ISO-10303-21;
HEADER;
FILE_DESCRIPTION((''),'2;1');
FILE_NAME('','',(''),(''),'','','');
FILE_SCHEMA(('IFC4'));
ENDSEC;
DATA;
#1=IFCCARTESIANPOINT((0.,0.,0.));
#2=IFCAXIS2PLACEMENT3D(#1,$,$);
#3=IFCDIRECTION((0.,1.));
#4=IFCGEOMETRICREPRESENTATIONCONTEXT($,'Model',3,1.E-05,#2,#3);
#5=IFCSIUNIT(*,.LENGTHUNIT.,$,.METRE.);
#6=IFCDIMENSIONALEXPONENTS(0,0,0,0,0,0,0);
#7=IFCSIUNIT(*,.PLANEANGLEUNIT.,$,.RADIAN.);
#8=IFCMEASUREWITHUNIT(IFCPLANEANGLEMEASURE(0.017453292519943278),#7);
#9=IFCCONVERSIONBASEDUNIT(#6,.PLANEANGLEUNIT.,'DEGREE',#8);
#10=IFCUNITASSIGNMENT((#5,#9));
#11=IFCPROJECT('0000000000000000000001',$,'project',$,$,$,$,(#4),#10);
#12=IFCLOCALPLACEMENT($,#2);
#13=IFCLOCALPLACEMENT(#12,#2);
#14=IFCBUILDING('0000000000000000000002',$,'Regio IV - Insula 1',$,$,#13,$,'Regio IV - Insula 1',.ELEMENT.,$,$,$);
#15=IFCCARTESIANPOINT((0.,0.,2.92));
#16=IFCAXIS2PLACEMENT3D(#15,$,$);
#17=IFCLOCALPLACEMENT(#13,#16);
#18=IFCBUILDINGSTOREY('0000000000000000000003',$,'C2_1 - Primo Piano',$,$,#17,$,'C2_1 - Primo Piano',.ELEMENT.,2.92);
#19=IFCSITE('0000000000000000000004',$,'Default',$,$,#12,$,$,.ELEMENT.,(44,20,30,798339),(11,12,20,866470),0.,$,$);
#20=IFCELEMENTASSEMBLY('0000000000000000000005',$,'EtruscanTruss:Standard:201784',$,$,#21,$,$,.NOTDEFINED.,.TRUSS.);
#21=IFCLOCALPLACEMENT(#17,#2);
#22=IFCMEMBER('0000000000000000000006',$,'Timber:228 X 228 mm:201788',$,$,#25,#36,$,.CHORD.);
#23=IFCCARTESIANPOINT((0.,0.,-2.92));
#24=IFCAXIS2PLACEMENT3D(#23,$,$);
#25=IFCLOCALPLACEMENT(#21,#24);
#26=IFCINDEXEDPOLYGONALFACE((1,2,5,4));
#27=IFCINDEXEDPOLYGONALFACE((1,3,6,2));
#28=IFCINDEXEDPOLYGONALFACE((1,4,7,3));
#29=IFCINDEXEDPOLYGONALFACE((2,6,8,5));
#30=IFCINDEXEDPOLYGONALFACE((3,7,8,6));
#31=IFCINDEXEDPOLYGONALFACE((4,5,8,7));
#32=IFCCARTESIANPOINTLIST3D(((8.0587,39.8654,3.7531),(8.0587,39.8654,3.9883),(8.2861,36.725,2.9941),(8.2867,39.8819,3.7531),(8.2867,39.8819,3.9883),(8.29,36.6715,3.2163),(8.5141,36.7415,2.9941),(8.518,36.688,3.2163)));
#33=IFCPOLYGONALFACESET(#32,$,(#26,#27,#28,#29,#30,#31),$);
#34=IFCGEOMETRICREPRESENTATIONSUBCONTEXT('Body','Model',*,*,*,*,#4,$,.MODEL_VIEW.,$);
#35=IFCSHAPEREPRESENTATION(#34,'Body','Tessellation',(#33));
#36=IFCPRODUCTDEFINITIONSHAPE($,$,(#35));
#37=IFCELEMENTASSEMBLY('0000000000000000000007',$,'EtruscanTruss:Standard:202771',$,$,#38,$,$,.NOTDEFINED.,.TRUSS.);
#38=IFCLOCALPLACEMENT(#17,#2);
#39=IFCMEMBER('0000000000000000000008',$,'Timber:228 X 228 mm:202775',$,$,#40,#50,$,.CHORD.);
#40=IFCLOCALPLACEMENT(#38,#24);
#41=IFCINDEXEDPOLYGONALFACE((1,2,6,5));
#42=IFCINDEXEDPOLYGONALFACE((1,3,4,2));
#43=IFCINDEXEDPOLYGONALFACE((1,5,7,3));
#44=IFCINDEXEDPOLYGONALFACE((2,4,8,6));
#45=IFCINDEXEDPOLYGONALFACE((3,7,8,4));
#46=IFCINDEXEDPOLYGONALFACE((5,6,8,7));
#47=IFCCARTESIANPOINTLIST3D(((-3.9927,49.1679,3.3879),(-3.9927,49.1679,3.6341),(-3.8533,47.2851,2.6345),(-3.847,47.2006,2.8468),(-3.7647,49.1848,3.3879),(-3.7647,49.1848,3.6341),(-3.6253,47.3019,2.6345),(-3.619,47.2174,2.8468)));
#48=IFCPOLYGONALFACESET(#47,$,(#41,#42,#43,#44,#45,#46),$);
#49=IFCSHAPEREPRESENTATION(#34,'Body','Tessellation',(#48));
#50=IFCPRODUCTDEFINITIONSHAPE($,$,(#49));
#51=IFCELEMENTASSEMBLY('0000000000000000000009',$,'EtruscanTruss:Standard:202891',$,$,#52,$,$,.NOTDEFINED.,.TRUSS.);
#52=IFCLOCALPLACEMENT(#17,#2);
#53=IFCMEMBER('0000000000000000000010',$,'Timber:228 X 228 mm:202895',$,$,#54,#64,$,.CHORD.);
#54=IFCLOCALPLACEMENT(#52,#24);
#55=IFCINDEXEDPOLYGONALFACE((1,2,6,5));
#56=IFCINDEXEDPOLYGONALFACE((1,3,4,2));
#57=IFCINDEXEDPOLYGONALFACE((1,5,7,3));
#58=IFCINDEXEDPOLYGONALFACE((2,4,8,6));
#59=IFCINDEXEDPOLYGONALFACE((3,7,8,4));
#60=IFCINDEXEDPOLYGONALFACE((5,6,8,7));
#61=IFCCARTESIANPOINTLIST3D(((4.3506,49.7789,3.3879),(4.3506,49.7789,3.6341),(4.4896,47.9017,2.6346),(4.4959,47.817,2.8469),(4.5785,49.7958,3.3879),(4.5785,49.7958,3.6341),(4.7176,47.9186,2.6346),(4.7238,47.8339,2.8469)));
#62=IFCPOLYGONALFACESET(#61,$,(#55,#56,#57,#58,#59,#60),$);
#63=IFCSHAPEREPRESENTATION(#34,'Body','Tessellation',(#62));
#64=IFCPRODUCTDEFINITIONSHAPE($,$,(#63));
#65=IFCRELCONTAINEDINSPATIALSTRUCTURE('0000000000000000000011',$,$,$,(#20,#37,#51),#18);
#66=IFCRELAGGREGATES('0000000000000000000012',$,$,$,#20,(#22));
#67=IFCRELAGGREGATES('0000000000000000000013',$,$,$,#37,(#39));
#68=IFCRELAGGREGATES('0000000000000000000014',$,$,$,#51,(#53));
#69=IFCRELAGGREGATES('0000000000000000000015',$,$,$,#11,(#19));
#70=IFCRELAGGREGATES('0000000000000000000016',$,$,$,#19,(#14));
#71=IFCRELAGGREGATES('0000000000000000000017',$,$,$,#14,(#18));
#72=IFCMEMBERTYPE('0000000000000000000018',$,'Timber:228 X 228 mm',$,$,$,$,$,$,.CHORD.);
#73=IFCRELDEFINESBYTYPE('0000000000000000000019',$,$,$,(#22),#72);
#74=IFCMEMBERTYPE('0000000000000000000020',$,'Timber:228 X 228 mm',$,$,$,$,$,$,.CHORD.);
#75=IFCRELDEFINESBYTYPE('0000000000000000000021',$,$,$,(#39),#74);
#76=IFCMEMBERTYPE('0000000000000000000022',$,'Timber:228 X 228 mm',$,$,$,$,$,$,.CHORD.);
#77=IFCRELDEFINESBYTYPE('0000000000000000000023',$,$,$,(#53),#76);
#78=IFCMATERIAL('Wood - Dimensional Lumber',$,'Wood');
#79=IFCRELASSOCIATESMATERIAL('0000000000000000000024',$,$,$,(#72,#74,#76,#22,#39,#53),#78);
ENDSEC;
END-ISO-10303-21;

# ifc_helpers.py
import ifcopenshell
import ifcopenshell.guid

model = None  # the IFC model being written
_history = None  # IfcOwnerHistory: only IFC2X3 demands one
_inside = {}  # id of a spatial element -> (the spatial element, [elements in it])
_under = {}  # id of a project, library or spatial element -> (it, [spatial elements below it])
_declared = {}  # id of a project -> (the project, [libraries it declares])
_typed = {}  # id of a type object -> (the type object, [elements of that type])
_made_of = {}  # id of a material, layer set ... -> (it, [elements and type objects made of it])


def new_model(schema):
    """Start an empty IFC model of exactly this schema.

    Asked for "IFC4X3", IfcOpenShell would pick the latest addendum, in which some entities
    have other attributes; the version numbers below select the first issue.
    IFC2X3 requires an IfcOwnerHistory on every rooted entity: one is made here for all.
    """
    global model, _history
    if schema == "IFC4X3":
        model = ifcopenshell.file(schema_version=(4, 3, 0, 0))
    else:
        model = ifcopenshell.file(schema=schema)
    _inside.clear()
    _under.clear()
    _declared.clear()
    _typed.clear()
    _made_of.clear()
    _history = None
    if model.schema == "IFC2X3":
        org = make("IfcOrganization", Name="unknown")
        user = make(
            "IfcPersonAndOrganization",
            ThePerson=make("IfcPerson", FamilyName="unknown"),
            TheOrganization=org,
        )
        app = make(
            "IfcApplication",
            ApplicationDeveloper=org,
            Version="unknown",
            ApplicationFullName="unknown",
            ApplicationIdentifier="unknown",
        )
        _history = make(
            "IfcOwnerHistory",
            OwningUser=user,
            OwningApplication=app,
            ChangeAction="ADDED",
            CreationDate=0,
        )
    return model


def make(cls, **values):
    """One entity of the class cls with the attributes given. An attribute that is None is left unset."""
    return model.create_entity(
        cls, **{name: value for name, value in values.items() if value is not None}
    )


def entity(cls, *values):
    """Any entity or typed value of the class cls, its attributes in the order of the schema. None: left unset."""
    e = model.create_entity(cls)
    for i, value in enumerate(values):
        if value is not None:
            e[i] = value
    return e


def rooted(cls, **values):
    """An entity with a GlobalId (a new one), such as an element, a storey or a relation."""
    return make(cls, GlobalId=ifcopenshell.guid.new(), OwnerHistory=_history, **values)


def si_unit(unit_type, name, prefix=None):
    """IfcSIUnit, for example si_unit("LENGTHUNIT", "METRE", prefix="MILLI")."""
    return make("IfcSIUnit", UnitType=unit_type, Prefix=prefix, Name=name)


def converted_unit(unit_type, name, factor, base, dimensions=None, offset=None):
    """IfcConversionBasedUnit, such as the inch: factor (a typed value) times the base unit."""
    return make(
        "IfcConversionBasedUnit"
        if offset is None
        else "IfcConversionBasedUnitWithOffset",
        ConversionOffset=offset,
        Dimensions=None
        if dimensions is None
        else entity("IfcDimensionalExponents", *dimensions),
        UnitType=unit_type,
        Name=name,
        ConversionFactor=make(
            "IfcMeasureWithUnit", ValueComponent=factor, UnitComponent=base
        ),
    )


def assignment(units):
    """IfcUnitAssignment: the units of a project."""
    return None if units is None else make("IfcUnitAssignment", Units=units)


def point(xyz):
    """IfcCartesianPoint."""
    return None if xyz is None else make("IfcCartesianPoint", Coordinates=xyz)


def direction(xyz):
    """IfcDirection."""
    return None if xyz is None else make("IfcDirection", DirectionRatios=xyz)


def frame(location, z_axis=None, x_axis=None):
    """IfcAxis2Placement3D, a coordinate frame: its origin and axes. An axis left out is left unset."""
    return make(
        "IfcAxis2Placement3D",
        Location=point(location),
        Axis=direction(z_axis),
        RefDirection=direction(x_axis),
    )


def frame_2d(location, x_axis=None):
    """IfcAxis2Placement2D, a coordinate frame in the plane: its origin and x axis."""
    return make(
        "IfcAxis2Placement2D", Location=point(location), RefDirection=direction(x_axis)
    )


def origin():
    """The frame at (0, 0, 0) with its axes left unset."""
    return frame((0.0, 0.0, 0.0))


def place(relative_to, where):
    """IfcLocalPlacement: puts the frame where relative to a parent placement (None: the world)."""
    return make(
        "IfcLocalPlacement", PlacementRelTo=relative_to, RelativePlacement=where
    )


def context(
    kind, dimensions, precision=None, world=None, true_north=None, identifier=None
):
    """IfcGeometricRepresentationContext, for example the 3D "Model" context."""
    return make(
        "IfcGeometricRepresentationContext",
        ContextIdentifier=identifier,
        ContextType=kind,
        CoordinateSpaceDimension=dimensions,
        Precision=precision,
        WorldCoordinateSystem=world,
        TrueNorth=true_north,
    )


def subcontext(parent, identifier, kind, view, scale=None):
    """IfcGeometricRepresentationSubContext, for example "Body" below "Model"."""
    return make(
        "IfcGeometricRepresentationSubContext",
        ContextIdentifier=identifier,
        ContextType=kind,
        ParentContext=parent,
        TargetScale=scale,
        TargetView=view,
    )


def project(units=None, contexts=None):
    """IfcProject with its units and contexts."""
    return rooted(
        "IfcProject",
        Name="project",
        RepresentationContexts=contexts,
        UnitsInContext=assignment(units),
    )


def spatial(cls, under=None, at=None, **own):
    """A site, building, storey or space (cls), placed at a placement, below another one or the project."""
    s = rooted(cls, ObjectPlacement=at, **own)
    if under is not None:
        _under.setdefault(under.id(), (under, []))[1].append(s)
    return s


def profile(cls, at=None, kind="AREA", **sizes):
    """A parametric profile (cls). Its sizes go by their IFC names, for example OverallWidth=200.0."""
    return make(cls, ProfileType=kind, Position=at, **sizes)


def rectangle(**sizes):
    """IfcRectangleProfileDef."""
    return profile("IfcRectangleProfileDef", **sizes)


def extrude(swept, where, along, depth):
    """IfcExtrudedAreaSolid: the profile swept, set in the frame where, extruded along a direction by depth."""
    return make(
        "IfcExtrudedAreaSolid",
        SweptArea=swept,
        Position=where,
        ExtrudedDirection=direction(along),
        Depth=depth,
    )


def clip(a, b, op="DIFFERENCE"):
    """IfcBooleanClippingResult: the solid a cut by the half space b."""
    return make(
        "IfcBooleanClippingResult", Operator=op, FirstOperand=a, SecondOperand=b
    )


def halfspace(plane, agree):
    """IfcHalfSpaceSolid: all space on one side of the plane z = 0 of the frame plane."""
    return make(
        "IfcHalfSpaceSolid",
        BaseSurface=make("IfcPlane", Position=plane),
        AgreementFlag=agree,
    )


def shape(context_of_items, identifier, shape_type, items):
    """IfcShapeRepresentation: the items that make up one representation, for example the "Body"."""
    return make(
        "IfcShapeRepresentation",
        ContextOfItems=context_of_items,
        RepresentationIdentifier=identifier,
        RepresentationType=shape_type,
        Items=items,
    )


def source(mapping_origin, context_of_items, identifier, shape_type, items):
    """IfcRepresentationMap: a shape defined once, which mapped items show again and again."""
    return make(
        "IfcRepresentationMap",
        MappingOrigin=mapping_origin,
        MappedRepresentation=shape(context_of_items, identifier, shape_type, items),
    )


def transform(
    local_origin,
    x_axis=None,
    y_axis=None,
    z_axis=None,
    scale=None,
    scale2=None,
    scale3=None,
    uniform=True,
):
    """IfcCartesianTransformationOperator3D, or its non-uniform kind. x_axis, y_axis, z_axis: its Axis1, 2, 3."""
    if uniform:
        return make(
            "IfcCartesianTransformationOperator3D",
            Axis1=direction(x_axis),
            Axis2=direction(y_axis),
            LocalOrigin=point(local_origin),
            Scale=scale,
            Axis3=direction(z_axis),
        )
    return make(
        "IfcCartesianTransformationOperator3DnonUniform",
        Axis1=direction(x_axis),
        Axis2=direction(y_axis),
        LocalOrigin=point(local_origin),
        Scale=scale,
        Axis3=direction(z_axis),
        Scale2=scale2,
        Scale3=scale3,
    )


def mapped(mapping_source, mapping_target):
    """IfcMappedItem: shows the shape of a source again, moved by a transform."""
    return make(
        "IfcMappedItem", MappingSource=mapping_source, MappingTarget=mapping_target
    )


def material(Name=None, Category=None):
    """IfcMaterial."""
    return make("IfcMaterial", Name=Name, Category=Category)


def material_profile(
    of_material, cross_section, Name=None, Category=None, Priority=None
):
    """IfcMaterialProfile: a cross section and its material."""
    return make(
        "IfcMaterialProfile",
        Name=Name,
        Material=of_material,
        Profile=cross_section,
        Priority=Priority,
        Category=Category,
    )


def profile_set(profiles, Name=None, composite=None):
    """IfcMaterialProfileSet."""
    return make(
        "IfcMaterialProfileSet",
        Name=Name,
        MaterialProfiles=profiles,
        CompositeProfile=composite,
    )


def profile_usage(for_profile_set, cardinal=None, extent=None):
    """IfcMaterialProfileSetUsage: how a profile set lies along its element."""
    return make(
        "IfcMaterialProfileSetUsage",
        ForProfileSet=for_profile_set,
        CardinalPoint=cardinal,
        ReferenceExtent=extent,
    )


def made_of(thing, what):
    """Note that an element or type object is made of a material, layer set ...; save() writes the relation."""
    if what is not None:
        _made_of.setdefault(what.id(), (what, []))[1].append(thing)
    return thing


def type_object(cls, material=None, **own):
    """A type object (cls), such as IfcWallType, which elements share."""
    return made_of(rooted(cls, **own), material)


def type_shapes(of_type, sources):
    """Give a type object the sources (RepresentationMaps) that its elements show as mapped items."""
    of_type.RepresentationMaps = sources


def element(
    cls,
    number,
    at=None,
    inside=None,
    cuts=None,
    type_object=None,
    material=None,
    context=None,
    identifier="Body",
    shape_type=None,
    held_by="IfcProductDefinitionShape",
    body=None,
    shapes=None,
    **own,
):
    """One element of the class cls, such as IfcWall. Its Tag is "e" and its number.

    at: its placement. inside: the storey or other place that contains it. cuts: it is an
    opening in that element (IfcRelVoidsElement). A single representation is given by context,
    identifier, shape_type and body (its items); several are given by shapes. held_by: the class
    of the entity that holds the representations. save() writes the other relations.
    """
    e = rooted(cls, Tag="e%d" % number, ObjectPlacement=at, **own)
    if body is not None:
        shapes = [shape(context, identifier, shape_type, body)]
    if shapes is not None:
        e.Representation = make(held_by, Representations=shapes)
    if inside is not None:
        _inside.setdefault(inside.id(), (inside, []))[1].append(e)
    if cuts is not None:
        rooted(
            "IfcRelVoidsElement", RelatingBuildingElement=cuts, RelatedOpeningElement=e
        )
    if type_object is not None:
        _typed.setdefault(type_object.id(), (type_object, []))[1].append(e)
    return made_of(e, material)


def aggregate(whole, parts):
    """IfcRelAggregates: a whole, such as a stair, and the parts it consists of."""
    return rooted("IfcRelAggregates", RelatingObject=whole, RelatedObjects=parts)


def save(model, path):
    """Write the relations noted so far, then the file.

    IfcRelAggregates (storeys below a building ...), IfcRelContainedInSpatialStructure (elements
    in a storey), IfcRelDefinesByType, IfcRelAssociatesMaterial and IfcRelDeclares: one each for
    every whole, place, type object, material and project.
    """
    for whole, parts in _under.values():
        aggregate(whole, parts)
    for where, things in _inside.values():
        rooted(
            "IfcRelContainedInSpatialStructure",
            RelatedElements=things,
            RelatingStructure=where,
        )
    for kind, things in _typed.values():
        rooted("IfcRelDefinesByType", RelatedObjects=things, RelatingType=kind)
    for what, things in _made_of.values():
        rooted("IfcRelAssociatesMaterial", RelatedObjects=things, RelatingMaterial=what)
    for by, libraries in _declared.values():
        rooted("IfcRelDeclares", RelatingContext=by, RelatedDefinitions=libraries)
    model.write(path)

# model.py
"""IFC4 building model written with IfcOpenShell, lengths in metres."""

from ifc_helpers import new_model, entity, si_unit, converted_unit, direction, frame, frame_2d, origin, place, context, subcontext, project, spatial, rectangle, extrude, clip, halfspace, source, transform, mapped, material, material_profile, profile_set, profile_usage, type_object, type_shapes, element, aggregate, save


model = new_model("IFC4")

# Units and contexts
model_context = context("Model", 3, precision=1e-05, world=origin(), true_north=direction((0.0, 1.0)))
body_context = subcontext(model_context, "Body", "Model", "MODEL_VIEW")
ifc_project = project(units=[si_unit("LENGTHUNIT", "METRE"), converted_unit("PLANEANGLEUNIT", "DEGREE", entity("IfcPlaneAngleMeasure", 0.017453292519943278), si_unit("PLANEANGLEUNIT", "RADIAN"), dimensions=[0, 0, 0, 0, 0, 0, 0])], contexts=[model_context])

# Site, building, storey
site_placement = place(None, origin())
site = spatial("IfcSite", under=ifc_project, at=site_placement, Name="Default", CompositionType="ELEMENT", RefLatitude=(44, 20, 30, 798339), RefLongitude=(11, 12, 20, 866470), RefElevation=0.0)
building_placement = place(site_placement, origin())
building = spatial("IfcBuilding", under=site, at=building_placement, Name="Regio IV - Insula 1", LongName="Regio IV - Insula 1", CompositionType="ELEMENT")
storey_placement = place(building_placement, frame((0.0, 0.0, 2.92)))
storey = spatial("IfcBuildingStorey", under=building, at=storey_placement, Name="C2_1 - Primo Piano", LongName="C2_1 - Primo Piano", CompositionType="ELEMENT", Elevation=2.92)

# Shared definitions
ifc_material_1 = material(Name="Wood - Dimensional Lumber", Category="Wood")
ifc_material_profile = material_profile(ifc_material_1, rectangle(XDim=8.091, YDim=0.2286, at=frame_2d((0.0, 0.0), x_axis=(1.0, 0.0))), Name="228 X 228 mm")
ifc_profile_set = profile_set([ifc_material_profile], Name="228 X 228 mm")

# Element assembly, member
assembly_1_placement = place(storey_placement, origin())
assembly_1 = element("IfcElementAssembly", 1, at=assembly_1_placement, inside=storey, Name="EtruscanTruss:Standard:201784", AssemblyPlace="NOTDEFINED", PredefinedType="TRUSS")
ifc_profile_usage_1 = profile_usage(ifc_profile_set)
member_type_1 = type_object("IfcMemberType", Name="Timber:228 X 228 mm", PredefinedType="CHORD", material=ifc_profile_set)
shared_shape_1 = source(origin(), body_context, "Body", "Clipping", [
    clip(extrude(rectangle(XDim=0.2286, YDim=0.2286, at=frame_2d((0.0, 0.0), x_axis=(0.0, 1.0))), frame((8.1708, 39.9004, 3.8771), z_axis=(0.070209, -0.969616, -0.234342), x_axis=(-0.997389, -0.07222, 0.0)), (0.0, 0.0, 1.0), 3.294), halfspace(frame((8.1727, 39.8737, 3.9883), z_axis=(-0.07222, 0.997389, 0.0), x_axis=(0.997389, 0.07222, 0.0)), False)),
])
type_shapes(member_type_1, [shared_shape_1])
member_1_placement = place(assembly_1_placement, frame((0.0, 0.0, -2.92)))
member_1 = element("IfcMember", 2, at=member_1_placement, type_object=member_type_1, material=ifc_profile_usage_1, Name="Timber:228 X 228 mm:201788", PredefinedType="CHORD", context=body_context, shape_type="MappedRepresentation", body=[
    mapped(shared_shape_1, transform((0.0, 0.0, 0.0), scale=1.0)),
])
aggregate(assembly_1, [member_1])

# Element assemblies, members
assembly_2_placement = place(storey_placement, origin())
assembly_2 = element("IfcElementAssembly", 3, at=assembly_2_placement, inside=storey, Name="EtruscanTruss:Standard:202771", AssemblyPlace="NOTDEFINED", PredefinedType="TRUSS")
member_type_2 = type_object("IfcMemberType", Name="Timber:228 X 228 mm", PredefinedType="CHORD", material=ifc_profile_set)
shared_shape_2 = source(origin(), body_context, "Body", "Clipping", [
    clip(extrude(rectangle(XDim=0.2286, YDim=0.2286, at=frame_2d((0.0, 0.0), x_axis=(0.0, 1.0))), frame((-3.8818, 49.2186, 3.5279), z_axis=(0.068596, -0.92624, -0.370641), x_axis=(-0.997269, -0.073857, 0.0)), (0.0, 0.0, 1.0), 2.124), halfspace(frame((-3.8787, 49.1763, 3.6341), z_axis=(-0.073857, 0.997269, 0.0), x_axis=(0.997269, 0.073857, 0.0)), False)),
])
type_shapes(member_type_2, [shared_shape_2])
member_2_placement = place(assembly_2_placement, frame((0.0, 0.0, -2.92)))
member_2 = element("IfcMember", 4, at=member_2_placement, type_object=member_type_2, material=ifc_profile_usage_1, Name="Timber:228 X 228 mm:202775", PredefinedType="CHORD", context=body_context, shape_type="MappedRepresentation", body=[
    mapped(shared_shape_2, transform((0.0, 0.0, 0.0), scale=1.0)),
])
aggregate(assembly_2, [member_2])
assembly_3_placement = place(storey_placement, origin())
assembly_3 = element("IfcElementAssembly", 5, at=assembly_3_placement, inside=storey, Name="EtruscanTruss:Standard:202891", AssemblyPlace="NOTDEFINED", PredefinedType="TRUSS")
member_type_3 = type_object("IfcMemberType", Name="Timber:228 X 228 mm", PredefinedType="CHORD", material=ifc_profile_set)
shared_shape_3 = source(origin(), body_context, "Body", "Clipping", [
    clip(extrude(rectangle(XDim=0.2286, YDim=0.2286, at=frame_2d((0.0, 0.0), x_axis=(0.0, 1.0))), frame((4.4614, 49.8297, 3.528), z_axis=(0.06857, -0.925887, -0.371527), x_axis=(-0.997269, -0.073857, 0.0)), (0.0, 0.0, 1.0), 2.1189), halfspace(frame((4.4645, 49.7873, 3.6341), z_axis=(-0.073857, 0.997269, 0.0), x_axis=(0.997269, 0.073857, 0.0)), False)),
])
type_shapes(member_type_3, [shared_shape_3])
member_3_placement = place(assembly_3_placement, frame((0.0, 0.0, -2.92)))
member_3 = element("IfcMember", 6, at=member_3_placement, type_object=member_type_3, material=ifc_profile_usage_1, Name="Timber:228 X 228 mm:202895", PredefinedType="CHORD", context=body_context, shape_type="MappedRepresentation", body=[
    mapped(shared_shape_3, transform((0.0, 0.0, 0.0), scale=1.0)),
])
aggregate(assembly_3, [member_3])

save(model, "model.ifc")
